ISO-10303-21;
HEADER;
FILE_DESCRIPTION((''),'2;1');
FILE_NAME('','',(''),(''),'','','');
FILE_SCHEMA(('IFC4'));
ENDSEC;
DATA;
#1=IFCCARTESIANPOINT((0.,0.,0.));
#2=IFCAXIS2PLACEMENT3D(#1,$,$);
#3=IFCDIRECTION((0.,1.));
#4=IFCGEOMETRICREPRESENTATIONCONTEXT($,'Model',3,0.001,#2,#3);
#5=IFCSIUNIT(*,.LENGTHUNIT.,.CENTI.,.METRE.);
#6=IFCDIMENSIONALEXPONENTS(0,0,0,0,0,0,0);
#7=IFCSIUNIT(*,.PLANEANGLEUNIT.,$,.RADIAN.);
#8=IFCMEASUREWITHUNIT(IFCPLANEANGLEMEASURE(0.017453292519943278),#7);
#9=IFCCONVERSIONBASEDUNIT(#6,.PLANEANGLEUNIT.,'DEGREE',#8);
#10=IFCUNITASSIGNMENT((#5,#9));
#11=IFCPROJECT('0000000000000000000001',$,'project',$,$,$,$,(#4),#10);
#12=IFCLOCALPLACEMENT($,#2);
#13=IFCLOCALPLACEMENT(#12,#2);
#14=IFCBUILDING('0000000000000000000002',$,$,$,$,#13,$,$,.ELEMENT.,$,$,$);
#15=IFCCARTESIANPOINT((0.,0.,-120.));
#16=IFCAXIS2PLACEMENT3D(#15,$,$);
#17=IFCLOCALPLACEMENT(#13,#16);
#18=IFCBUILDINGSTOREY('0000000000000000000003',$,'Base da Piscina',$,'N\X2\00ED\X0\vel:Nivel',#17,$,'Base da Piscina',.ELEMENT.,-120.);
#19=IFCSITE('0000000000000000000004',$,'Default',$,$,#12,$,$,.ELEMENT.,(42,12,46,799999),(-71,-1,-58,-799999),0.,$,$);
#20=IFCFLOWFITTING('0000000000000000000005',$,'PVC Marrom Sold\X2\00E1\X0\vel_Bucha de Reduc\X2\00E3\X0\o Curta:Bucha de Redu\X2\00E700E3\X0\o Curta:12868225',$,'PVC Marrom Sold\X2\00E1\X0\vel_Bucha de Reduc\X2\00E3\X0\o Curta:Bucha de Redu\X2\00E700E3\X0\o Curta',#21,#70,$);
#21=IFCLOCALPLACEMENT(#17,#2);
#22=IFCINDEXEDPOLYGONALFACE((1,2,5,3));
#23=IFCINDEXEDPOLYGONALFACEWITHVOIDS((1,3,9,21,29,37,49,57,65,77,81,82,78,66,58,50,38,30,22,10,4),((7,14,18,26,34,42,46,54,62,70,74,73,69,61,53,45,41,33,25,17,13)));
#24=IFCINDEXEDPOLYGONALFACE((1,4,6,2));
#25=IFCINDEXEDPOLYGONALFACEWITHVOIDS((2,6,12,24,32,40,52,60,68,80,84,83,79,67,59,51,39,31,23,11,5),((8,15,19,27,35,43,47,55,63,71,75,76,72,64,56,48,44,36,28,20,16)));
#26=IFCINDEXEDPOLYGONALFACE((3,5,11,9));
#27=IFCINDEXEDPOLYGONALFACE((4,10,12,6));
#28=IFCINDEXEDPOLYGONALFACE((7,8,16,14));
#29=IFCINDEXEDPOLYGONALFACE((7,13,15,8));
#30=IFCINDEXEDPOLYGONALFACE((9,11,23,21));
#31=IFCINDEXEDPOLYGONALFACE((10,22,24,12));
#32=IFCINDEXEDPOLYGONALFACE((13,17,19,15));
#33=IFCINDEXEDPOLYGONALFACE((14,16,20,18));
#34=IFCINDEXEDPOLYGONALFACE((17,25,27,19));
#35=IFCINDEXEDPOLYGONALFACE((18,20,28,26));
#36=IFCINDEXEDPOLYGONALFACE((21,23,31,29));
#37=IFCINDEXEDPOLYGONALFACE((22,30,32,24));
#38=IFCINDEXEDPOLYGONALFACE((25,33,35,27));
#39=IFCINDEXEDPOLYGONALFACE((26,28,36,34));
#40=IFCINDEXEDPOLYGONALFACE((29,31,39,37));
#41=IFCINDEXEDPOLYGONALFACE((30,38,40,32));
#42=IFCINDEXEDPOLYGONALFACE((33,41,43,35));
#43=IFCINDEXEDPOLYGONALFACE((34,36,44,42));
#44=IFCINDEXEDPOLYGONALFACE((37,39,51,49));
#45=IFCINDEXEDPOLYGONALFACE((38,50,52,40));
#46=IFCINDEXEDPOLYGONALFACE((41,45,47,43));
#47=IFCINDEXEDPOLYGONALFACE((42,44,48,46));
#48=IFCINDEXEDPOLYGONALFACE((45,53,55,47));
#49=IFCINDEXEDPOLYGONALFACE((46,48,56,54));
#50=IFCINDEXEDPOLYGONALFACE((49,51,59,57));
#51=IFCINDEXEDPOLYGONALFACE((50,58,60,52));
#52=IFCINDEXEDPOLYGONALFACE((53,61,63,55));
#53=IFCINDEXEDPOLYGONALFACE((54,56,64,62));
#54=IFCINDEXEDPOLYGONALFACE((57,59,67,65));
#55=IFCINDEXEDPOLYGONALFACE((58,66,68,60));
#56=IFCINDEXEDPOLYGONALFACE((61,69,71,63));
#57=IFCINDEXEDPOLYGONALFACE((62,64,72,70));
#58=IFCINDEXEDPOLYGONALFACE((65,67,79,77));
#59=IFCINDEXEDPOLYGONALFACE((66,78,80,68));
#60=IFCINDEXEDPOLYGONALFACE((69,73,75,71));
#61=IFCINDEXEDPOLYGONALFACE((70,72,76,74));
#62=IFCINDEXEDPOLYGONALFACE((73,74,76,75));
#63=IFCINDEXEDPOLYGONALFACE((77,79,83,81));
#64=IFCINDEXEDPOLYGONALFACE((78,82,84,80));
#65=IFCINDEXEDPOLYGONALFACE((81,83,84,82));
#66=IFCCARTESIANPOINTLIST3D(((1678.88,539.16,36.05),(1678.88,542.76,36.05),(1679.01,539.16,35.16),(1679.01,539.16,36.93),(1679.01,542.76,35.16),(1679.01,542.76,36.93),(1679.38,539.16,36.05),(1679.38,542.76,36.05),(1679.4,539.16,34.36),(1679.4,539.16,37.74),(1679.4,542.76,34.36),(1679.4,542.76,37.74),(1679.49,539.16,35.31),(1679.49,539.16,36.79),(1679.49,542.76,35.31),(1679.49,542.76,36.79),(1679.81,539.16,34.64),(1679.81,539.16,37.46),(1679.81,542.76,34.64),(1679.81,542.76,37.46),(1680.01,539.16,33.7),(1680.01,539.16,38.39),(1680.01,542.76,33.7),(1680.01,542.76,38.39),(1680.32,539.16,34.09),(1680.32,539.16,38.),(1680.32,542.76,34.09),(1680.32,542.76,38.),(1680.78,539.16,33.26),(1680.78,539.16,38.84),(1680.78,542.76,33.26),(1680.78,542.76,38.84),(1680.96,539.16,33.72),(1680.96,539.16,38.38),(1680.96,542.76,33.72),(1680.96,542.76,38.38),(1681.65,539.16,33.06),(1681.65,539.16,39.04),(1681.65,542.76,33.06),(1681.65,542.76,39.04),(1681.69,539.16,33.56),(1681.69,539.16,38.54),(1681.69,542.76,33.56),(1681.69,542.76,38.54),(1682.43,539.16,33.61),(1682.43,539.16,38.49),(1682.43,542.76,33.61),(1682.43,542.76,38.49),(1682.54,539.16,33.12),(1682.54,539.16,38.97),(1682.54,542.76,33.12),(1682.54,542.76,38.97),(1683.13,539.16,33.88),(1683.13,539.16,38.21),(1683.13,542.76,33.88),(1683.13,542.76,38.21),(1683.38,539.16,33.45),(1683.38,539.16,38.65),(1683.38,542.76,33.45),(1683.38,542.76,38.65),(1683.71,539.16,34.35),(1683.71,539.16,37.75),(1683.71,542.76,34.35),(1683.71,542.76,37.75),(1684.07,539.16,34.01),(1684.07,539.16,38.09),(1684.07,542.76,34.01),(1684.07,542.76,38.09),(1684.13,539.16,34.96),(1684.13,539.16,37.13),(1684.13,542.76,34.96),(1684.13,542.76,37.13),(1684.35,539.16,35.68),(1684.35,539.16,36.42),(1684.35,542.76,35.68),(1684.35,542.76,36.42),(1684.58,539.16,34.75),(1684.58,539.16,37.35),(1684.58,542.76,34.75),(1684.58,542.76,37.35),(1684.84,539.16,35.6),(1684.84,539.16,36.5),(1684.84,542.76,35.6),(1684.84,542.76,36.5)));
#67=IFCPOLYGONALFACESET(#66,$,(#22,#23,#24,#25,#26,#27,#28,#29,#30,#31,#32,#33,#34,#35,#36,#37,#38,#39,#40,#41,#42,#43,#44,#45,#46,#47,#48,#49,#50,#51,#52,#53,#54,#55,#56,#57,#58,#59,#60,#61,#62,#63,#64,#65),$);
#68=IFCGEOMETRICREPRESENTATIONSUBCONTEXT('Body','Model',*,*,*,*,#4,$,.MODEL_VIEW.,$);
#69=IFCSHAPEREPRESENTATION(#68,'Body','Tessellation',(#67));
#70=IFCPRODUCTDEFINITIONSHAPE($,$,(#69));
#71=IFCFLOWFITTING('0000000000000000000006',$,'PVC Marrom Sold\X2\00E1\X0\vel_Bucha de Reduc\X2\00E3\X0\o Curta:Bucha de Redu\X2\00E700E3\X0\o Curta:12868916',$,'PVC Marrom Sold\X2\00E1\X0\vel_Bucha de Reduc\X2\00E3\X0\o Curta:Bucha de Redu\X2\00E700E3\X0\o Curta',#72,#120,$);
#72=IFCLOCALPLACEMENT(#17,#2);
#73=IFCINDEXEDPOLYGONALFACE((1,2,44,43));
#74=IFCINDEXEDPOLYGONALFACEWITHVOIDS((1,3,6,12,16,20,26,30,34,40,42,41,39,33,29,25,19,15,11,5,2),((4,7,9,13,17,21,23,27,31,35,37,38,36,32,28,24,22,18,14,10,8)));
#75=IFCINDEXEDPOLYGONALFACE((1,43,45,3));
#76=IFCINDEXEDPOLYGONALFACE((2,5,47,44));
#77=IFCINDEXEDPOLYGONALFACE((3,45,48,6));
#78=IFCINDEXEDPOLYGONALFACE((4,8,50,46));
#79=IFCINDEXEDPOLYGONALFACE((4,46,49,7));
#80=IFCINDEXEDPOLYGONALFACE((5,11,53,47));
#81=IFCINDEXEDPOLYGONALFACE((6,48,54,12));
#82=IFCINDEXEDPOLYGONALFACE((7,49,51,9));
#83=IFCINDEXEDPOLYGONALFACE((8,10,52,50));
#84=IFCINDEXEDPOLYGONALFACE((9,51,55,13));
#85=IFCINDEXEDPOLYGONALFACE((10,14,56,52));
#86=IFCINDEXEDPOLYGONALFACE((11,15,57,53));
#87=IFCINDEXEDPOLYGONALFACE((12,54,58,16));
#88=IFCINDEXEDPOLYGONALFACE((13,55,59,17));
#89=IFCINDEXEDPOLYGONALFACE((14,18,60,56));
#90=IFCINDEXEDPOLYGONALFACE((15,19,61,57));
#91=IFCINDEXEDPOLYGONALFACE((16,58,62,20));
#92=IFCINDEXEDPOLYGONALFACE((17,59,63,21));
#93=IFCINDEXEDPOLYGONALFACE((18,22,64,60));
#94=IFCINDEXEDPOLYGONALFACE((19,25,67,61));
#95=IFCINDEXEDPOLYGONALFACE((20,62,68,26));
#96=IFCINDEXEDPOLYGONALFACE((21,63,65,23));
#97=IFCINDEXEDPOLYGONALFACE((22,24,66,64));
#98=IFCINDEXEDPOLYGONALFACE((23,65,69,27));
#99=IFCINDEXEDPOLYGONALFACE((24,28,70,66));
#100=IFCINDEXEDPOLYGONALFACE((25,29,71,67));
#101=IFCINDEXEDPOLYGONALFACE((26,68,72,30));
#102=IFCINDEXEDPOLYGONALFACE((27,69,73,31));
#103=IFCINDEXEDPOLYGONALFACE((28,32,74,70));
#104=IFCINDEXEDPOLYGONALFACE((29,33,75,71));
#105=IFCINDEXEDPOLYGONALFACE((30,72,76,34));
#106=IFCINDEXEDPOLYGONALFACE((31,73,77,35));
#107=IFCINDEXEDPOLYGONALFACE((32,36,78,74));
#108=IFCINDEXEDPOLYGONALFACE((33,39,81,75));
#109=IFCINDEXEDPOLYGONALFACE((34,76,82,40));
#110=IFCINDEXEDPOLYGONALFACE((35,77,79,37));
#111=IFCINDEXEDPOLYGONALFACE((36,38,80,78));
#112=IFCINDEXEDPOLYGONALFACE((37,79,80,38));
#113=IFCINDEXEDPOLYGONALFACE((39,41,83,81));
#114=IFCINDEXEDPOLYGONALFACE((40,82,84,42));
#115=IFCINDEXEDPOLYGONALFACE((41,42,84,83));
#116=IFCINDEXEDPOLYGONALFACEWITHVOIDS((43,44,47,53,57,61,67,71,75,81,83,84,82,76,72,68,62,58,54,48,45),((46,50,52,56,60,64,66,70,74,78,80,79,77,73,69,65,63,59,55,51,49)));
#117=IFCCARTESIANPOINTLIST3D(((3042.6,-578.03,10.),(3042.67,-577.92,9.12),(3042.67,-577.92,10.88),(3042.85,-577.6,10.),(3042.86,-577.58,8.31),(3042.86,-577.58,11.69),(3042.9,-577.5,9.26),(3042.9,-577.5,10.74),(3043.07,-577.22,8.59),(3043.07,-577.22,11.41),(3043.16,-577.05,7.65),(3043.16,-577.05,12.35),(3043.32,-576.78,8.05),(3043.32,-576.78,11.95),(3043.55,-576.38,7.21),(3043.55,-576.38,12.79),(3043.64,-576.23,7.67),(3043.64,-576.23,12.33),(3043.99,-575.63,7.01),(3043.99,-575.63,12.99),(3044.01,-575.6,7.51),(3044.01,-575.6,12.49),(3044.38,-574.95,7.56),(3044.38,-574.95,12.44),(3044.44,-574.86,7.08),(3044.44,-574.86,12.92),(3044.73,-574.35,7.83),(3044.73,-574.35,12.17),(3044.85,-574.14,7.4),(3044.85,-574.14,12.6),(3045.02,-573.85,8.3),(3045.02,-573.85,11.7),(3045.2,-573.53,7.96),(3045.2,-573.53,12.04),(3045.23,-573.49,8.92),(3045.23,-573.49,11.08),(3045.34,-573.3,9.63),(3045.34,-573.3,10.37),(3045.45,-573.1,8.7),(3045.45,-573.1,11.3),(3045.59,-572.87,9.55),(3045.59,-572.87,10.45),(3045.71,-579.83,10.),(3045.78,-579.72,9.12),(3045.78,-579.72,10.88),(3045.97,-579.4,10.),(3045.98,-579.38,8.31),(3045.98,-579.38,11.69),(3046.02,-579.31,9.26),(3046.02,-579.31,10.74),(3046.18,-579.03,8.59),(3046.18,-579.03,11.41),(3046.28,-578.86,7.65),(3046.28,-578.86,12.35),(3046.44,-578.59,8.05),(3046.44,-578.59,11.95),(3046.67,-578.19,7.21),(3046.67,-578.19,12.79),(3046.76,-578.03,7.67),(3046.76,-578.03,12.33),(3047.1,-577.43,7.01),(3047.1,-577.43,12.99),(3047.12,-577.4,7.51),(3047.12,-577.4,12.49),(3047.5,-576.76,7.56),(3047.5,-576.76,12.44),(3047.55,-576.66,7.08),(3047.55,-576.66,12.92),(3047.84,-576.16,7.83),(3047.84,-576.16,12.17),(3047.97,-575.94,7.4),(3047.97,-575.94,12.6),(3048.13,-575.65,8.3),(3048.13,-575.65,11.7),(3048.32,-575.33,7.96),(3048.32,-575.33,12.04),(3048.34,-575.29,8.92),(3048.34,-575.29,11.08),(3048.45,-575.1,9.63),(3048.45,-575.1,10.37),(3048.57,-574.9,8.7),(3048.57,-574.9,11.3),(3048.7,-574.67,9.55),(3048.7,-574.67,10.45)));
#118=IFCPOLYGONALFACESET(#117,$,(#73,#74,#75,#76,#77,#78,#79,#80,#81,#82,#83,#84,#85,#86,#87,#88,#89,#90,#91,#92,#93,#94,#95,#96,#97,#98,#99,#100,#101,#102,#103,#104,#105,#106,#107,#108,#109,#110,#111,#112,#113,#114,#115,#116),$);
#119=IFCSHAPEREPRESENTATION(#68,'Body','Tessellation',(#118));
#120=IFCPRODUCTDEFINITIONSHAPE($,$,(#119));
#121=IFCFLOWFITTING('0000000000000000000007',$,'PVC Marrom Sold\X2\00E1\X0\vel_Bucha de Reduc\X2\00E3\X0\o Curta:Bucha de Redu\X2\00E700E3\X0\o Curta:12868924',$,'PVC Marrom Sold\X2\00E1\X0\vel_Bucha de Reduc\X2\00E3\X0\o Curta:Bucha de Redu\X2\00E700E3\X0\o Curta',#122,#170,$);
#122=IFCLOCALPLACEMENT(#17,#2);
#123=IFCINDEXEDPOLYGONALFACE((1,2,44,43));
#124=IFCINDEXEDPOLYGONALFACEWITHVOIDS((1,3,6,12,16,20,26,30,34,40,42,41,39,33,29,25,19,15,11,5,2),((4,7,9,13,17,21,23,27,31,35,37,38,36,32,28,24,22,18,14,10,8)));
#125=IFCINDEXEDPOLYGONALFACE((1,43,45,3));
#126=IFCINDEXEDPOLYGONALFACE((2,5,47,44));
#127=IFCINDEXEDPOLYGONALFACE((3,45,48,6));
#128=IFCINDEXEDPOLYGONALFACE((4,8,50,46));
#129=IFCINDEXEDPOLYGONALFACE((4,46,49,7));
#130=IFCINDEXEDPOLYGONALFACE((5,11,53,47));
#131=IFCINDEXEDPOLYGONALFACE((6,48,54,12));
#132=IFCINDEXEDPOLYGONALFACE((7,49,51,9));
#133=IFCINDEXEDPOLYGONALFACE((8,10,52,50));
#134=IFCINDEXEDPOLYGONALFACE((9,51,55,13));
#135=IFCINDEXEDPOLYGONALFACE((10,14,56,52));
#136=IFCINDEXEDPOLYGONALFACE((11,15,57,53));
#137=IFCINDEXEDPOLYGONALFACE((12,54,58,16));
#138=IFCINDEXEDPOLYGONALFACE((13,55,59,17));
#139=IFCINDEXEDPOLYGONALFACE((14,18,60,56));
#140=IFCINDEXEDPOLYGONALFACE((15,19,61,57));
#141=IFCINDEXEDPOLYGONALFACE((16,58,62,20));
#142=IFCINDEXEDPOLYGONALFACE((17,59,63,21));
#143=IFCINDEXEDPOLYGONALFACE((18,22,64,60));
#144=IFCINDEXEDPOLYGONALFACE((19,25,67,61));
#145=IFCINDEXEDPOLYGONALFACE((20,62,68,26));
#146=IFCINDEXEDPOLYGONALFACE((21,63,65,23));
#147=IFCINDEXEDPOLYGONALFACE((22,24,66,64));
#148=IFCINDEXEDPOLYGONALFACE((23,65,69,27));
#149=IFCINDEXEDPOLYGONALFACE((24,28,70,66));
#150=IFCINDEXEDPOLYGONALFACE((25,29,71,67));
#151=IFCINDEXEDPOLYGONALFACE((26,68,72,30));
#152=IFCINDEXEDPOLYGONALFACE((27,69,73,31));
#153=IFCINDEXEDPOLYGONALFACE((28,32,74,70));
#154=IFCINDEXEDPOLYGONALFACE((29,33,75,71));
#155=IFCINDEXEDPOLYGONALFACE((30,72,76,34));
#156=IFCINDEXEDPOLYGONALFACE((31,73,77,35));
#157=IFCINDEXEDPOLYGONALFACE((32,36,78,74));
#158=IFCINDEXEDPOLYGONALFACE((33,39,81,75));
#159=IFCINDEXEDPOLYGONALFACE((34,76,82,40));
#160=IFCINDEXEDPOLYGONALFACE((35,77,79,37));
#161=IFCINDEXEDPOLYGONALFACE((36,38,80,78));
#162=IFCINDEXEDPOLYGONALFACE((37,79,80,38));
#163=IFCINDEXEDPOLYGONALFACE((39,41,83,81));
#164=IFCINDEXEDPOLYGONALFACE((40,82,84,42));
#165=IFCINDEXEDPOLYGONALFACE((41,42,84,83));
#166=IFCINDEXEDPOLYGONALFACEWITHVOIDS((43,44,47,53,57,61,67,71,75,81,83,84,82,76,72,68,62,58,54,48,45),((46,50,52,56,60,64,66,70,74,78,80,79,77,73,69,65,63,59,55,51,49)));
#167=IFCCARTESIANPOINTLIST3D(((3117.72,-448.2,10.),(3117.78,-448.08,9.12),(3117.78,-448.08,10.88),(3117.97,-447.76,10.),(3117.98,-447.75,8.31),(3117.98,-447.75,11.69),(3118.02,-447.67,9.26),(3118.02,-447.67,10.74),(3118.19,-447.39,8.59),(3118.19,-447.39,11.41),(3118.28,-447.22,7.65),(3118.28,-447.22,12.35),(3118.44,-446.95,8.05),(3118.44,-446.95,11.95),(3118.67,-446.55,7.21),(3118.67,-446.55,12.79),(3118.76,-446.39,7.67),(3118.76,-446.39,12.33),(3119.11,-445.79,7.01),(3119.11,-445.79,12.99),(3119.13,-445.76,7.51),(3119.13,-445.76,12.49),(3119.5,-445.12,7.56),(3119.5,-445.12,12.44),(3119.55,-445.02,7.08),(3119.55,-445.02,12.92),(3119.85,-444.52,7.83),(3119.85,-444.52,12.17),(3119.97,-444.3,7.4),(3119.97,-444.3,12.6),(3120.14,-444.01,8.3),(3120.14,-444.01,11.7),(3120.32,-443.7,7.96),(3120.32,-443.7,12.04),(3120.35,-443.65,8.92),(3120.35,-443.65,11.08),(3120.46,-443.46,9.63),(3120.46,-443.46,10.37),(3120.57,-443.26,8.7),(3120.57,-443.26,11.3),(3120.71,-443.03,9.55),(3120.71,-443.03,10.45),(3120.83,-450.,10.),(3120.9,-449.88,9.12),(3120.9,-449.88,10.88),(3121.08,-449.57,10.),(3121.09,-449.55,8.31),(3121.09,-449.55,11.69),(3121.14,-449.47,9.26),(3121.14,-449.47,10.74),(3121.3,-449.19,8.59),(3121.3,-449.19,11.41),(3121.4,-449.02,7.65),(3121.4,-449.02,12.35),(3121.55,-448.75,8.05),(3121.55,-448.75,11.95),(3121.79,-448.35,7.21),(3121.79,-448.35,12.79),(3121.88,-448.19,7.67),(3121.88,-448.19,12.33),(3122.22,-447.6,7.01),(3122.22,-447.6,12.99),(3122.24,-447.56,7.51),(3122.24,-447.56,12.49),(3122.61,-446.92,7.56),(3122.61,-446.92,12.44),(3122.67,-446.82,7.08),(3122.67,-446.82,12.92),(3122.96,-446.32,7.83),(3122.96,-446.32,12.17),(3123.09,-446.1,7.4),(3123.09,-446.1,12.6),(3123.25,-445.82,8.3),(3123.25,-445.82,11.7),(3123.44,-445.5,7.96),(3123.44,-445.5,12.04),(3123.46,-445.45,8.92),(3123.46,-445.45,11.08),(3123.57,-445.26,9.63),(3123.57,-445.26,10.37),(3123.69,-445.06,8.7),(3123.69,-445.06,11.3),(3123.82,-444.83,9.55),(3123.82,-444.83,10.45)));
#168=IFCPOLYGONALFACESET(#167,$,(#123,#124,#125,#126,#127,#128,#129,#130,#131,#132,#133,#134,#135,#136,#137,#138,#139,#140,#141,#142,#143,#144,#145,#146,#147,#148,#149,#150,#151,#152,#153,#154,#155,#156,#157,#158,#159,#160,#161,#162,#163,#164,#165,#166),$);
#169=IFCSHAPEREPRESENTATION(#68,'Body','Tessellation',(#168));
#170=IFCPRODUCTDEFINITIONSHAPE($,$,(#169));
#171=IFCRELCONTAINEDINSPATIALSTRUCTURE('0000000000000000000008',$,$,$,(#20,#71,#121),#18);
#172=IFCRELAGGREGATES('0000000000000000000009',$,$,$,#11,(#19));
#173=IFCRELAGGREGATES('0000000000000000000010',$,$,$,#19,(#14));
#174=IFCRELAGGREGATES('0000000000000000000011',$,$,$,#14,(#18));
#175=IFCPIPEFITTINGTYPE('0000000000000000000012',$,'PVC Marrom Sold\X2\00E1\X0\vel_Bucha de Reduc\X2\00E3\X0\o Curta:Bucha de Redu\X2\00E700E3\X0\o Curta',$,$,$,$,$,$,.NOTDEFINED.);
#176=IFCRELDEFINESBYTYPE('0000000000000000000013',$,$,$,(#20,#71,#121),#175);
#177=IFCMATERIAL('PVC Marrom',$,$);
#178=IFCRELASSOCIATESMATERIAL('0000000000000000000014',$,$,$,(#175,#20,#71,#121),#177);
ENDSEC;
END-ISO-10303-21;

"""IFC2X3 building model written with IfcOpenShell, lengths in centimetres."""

from ifc_helpers import new_model, entity, si_unit, converted_unit, direction, frame, frame_2d, origin, place, context, subcontext, project, spatial, hollow_circle, extrude, source, transform, mapped, material, type_object, type_shapes, element, save


model = new_model("IFC2X3")

# Units and contexts
model_context = context("Model", 3, precision=0.001, world=origin(), true_north=direction((0.0, 1.0)))
body_context = subcontext(model_context, "Body", "Model", "MODEL_VIEW")
ifc_project = project(units=[si_unit("LENGTHUNIT", "METRE", prefix="CENTI"), converted_unit("PLANEANGLEUNIT", "DEGREE", entity("IfcPlaneAngleMeasure", 0.017453292519943278), si_unit("PLANEANGLEUNIT", "RADIAN"), dimensions=[0, 0, 0, 0, 0, 0, 0])], contexts=[model_context])

# Site, building, storey
site_placement = place(None, origin())
site = spatial("IfcSite", under=ifc_project, at=site_placement, Name="Default", CompositionType="ELEMENT", RefLatitude=(42, 12, 46, 799999), RefLongitude=(-71, -1, -58, -799999), RefElevation=0.0)
building_placement = place(site_placement, origin())
building = spatial("IfcBuilding", under=site, at=building_placement, CompositionType="ELEMENT")
storey_placement = place(building_placement, frame((0.0, 0.0, -120.0)))
storey = spatial("IfcBuildingStorey", under=building, at=storey_placement, Name="Base da Piscina", ObjectType="Nível:Nivel", LongName="Base da Piscina", CompositionType="ELEMENT", Elevation=-120.0)

# Flow fittings
ifc_material_1 = material(Name="PVC Marrom")
pipe_fitting_type_1 = type_object("IfcPipeFittingType", Name="PVC Marrom Soldável_Bucha de Reducão Curta:Bucha de Redução Curta", PredefinedType="NOTDEFINED", material=ifc_material_1)
shared_shape_1 = source(origin(), body_context, "Body", "SweptSolid", [
    extrude(hollow_circle(Radius=3.0, WallThickness=0.5, at=frame_2d((0.0, 0.0), x_axis=(1.0, 0.0))), frame((0.0, 0.0, 0.0), z_axis=(1.0, 0.0, 0.0), x_axis=(0.0, 1.0, 0.0)), (0.0, 0.0, 1.0), 3.6),
])
type_shapes(pipe_fitting_type_1, [shared_shape_1])
for number, where, z_axis, x_axis, name in (
    (1, (1681.88, 539.16, 36.05), (0.0, 0.0, 1.0), (0.0, 1.0, 0.0), "PVC Marrom Soldável_Bucha de Reducão Curta:Bucha de Redução Curta:12868225"),
    (2, (3047.22, -577.24, 10.0), (0.0, 0.0, 1.0), (-0.865569, 0.50079, 0.0), "PVC Marrom Soldável_Bucha de Reducão Curta:Bucha de Redução Curta:12868916"),
    (3, (3122.34, -447.4, 10.0), (0.0, 0.0, 1.0), (-0.865569, 0.50079, 0.0), "PVC Marrom Soldável_Bucha de Reducão Curta:Bucha de Redução Curta:12868924"),
):
    element("IfcFlowFitting", number, at=place(storey_placement, frame(where, z_axis=z_axis, x_axis=x_axis)), inside=storey, type_object=pipe_fitting_type_1, material=ifc_material_1, Name=name, ObjectType="PVC Marrom Soldável_Bucha de Reducão Curta:Bucha de Redução Curta", context=body_context, shape_type="MappedRepresentation", body=[
        mapped(shared_shape_1, transform((0.0, 0.0, 0.0), scale=1.0)),
    ])

save(model, "model.ifc")
